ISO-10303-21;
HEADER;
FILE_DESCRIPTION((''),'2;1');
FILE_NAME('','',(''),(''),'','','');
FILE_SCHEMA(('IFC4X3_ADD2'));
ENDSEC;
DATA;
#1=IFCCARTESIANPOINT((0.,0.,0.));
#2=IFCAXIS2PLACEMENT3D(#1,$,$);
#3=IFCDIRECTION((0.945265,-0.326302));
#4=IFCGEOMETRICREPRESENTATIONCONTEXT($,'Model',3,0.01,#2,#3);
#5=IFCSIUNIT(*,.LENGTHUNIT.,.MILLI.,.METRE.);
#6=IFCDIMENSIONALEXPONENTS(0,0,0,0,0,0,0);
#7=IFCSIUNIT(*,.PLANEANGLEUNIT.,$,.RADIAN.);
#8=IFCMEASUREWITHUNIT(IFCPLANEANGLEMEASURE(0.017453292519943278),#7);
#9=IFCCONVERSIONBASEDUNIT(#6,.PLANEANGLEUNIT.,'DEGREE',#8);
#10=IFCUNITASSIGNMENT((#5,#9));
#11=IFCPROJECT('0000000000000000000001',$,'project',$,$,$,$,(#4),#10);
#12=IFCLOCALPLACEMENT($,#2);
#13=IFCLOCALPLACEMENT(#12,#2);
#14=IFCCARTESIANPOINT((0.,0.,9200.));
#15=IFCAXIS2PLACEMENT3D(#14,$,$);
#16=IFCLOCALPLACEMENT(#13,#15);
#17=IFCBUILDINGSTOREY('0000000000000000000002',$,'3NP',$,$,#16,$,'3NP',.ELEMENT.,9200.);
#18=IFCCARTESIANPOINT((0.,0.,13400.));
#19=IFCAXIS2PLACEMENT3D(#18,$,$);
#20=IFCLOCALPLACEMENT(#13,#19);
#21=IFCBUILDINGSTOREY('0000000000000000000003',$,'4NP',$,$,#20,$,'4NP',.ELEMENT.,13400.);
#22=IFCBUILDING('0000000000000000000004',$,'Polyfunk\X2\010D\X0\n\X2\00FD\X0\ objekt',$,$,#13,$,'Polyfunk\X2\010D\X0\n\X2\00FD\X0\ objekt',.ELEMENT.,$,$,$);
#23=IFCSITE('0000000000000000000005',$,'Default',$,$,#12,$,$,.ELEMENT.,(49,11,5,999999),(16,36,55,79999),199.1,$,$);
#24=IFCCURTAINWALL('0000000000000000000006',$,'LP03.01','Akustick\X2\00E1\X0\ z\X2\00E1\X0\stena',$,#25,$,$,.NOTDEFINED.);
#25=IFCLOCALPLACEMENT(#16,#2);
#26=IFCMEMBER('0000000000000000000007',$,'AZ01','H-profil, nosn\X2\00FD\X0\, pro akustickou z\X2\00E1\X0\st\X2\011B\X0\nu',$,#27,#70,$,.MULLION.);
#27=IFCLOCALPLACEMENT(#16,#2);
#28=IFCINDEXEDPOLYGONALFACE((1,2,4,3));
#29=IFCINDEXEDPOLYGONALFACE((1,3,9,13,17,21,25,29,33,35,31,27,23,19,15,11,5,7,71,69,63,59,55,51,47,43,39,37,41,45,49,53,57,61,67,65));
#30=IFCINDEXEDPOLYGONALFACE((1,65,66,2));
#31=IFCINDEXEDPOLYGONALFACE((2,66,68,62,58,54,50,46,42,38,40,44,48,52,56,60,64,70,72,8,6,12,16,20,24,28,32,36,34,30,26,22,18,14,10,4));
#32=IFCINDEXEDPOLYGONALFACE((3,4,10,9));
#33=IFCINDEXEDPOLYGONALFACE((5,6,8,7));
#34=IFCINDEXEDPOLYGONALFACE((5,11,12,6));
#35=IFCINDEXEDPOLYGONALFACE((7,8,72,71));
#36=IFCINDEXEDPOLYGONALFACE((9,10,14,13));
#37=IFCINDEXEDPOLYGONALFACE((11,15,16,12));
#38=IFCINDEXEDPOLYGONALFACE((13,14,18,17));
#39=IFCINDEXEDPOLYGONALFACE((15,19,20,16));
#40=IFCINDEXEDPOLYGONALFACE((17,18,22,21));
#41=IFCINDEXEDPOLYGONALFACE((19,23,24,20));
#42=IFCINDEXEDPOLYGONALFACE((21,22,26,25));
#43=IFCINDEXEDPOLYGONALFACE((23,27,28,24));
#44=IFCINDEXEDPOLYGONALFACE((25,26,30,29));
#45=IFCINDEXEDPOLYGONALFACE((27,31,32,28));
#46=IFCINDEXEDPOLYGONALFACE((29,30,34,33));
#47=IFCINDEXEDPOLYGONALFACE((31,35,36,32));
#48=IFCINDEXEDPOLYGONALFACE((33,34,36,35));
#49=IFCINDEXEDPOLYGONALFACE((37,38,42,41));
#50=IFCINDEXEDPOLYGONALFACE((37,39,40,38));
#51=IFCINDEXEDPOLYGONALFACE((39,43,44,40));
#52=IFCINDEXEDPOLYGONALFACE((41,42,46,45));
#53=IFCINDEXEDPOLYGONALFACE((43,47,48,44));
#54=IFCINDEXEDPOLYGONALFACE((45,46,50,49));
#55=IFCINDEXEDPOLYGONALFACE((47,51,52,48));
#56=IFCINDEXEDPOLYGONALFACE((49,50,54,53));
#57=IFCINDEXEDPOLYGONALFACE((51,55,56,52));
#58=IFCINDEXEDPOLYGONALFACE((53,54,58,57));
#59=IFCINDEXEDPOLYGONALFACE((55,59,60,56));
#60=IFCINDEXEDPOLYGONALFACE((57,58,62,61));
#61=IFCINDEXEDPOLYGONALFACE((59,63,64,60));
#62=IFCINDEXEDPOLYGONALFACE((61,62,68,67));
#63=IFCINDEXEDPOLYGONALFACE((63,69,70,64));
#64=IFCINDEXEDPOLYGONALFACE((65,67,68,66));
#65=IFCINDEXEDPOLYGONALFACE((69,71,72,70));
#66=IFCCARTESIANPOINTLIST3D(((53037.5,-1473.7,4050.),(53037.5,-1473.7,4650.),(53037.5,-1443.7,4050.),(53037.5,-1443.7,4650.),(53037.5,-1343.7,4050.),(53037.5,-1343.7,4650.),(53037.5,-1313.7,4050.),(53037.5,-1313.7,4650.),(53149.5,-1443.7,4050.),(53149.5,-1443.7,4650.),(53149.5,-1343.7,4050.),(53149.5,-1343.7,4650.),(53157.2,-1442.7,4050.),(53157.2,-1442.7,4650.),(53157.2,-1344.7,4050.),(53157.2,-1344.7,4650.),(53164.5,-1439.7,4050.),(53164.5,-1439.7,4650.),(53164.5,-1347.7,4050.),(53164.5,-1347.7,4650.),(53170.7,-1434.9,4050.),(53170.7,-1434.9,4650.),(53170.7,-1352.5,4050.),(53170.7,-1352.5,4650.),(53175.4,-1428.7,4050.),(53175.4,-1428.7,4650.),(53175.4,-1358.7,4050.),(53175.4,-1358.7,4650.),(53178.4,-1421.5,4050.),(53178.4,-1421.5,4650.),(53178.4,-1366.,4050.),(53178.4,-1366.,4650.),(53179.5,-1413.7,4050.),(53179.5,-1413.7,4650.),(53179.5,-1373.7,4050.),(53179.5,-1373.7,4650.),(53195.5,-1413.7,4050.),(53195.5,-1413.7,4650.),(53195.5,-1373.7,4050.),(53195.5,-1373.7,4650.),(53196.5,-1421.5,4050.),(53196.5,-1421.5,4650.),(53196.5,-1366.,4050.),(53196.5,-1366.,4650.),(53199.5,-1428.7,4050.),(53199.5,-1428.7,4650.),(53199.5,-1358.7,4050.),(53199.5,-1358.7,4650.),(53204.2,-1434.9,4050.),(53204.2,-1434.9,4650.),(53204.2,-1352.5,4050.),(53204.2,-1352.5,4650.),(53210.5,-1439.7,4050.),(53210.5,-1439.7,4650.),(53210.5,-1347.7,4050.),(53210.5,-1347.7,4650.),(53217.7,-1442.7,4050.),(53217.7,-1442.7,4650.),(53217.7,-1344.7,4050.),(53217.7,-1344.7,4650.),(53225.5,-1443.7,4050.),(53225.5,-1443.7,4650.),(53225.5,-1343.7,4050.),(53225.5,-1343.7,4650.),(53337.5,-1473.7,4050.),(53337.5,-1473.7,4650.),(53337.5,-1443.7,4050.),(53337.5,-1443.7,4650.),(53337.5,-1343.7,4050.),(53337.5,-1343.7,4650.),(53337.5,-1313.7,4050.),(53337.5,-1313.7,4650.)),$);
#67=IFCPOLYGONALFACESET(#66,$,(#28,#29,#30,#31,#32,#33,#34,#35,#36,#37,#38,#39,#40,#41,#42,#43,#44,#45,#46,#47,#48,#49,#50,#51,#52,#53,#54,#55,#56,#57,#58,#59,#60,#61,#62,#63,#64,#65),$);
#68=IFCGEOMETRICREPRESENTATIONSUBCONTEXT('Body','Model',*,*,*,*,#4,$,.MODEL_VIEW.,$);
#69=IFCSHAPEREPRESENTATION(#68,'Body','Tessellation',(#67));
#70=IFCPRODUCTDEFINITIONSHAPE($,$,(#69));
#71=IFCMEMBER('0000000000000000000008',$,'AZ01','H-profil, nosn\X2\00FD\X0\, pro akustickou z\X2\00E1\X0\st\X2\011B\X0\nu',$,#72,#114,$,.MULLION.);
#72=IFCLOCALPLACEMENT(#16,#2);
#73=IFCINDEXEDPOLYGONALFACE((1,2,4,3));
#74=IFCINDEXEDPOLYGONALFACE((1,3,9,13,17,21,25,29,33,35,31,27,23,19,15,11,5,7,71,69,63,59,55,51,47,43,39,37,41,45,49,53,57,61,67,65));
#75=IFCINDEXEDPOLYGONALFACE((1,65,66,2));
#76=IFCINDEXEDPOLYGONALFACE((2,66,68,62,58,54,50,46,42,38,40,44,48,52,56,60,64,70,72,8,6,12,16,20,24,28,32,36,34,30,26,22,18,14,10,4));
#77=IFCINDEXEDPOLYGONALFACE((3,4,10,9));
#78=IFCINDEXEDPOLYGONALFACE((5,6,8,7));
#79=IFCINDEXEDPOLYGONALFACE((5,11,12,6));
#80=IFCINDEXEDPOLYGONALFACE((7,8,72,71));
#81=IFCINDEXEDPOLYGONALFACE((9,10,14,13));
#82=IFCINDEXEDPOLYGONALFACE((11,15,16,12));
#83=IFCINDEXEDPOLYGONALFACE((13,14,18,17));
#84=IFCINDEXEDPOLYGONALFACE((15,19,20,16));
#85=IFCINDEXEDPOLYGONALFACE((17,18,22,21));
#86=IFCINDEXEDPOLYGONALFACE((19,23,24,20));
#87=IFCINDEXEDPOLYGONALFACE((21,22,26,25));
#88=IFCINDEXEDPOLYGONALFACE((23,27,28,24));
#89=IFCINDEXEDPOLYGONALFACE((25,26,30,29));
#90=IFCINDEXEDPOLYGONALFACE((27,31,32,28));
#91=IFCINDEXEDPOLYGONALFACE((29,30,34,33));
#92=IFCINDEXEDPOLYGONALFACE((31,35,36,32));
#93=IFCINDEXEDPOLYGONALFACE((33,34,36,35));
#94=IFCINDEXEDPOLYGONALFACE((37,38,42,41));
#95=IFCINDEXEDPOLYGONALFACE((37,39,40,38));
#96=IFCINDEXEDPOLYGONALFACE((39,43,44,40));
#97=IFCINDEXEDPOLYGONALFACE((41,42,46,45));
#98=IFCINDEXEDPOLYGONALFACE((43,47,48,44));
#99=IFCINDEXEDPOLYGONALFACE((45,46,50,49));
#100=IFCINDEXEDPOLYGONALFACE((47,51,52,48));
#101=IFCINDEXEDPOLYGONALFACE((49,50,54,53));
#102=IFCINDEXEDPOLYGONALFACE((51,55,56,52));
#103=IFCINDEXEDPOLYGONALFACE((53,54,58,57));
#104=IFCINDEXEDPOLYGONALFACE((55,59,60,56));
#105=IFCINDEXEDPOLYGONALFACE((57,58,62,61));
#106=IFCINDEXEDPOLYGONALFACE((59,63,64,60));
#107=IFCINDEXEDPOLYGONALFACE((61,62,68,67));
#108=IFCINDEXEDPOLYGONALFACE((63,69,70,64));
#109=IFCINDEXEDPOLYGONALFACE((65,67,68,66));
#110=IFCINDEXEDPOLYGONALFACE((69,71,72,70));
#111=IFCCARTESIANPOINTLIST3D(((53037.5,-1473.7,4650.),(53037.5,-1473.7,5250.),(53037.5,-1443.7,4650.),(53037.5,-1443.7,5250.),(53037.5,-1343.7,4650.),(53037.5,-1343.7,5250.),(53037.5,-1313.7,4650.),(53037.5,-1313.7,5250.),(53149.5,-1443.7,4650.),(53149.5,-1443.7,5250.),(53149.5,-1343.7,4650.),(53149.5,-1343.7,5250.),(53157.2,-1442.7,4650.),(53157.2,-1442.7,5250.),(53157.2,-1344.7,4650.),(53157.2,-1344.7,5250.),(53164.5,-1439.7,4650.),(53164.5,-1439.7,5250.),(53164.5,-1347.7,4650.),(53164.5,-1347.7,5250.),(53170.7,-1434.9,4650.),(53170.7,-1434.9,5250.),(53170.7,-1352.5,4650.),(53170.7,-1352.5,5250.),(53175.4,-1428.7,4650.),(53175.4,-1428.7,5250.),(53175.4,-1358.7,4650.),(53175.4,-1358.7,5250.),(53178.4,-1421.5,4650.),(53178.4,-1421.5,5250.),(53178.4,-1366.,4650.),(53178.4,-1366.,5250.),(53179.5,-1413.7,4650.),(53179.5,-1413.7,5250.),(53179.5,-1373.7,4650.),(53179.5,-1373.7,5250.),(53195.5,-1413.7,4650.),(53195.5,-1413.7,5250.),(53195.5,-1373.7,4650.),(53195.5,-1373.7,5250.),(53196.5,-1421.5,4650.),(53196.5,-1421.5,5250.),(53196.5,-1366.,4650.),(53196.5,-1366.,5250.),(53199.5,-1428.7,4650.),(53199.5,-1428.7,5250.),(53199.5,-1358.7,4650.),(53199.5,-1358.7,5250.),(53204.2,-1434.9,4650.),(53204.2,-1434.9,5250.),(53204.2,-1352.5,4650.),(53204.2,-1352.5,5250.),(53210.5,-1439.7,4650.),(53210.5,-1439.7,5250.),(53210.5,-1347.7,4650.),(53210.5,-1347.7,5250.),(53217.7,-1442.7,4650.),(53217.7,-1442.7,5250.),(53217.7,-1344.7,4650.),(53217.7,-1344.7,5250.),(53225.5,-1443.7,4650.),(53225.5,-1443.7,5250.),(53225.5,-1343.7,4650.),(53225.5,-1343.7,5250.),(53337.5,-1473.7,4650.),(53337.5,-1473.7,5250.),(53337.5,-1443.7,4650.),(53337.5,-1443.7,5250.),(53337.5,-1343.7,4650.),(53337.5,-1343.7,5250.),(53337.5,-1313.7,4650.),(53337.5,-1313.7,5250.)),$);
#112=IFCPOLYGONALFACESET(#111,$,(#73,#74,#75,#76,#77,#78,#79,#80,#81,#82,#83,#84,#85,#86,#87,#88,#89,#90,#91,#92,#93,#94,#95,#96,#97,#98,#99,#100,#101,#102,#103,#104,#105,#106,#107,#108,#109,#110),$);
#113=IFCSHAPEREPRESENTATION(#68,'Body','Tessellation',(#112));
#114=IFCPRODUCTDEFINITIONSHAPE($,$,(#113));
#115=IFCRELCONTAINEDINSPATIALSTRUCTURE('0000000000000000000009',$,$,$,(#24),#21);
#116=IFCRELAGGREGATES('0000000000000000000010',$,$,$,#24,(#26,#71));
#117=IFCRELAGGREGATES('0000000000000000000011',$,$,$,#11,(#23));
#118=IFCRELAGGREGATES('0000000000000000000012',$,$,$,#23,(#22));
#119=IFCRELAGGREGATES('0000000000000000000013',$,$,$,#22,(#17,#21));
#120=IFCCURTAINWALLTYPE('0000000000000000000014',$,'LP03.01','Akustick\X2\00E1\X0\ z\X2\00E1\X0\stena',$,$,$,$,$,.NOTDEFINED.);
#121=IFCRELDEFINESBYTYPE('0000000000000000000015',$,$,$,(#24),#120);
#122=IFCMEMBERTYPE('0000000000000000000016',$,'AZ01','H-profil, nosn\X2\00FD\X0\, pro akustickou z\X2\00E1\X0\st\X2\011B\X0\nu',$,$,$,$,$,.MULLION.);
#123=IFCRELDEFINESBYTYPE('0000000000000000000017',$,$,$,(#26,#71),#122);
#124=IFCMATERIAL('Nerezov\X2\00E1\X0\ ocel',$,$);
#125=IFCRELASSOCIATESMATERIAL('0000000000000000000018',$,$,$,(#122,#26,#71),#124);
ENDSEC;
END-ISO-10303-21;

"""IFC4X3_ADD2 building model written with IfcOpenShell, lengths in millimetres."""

from ifc_helpers import new_model, entity, si_unit, converted_unit, direction, frame, frame_2d, origin, place, context, subcontext, project, spatial, polyline, circle_curve, parameter, trimmed, segment, composite_curve, outline, extrude, source, transform, mapped, material, material_profile, profile_set, profile_usage, type_object, element, aggregate, save


model = new_model("IFC4X3_ADD2")

# Units and contexts
model_context = context("Model", 3, precision=0.01, world=origin(), true_north=direction((0.945265, -0.326302)))
body_context = subcontext(model_context, "Body", "Model", "MODEL_VIEW")
ifc_project = project(units=[si_unit("LENGTHUNIT", "METRE", prefix="MILLI"), converted_unit("PLANEANGLEUNIT", "DEGREE", entity("IfcPlaneAngleMeasure", 0.017453292519943278), si_unit("PLANEANGLEUNIT", "RADIAN"), dimensions=[0, 0, 0, 0, 0, 0, 0])], contexts=[model_context])

# Site, building, storey
site_placement = place(None, origin())
site = spatial("IfcSite", under=ifc_project, at=site_placement, Name="Default", CompositionType="ELEMENT", RefLatitude=(49, 11, 5, 999999), RefLongitude=(16, 36, 55, 79999), RefElevation=199.1)
building_placement = place(site_placement, origin())
building = spatial("IfcBuilding", under=site, at=building_placement, Name="Polyfunkčný objekt", LongName="Polyfunkčný objekt", CompositionType="ELEMENT")
storey_1_placement = place(building_placement, frame((0.0, 0.0, 9200.0)))
storey_1 = spatial("IfcBuildingStorey", under=building, at=storey_1_placement, Name="3NP", LongName="3NP", CompositionType="ELEMENT", Elevation=9200.0)

# Shared definitions
storey_2_placement = place(building_placement, frame((0.0, 0.0, 13400.0)))
storey_2 = spatial("IfcBuildingStorey", under=building, at=storey_2_placement, Name="4NP", LongName="4NP", CompositionType="ELEMENT", Elevation=13400.0)

# Curtain wall, members
curtain_wall_type_1 = type_object("IfcCurtainWallType", Name="LP03.01", Description="Akustická zástena", PredefinedType="NOTDEFINED")
curtain_wall_1_placement = place(storey_2_placement, frame((0.0, 0.0, -13400.0)))
curtain_wall_1 = element("IfcCurtainWall", 1, at=curtain_wall_1_placement, inside=storey_2, type_object=curtain_wall_type_1, Name="LP03.01", Description="Akustická zástena", PredefinedType="NOTDEFINED")
ifc_material_1 = material(Name="Nerezová ocel")
ifc_material_profile_1 = material_profile(ifc_material_1, outline(composite_curve([segment(polyline([(50.0, -150.0), (80.0, -150.0)]), True, "CONTINUOUS"), segment(polyline([(80.0, -150.0), (80.0, 150.0)]), True, "CONTINUOUS"), segment(polyline([(80.0, 150.0), (50.0, 150.0)]), True, "CONTINUOUS"), segment(polyline([(50.0, 150.0), (50.0, 38.0)]), True, "CONTINUOUS"), segment(trimmed(circle_curve(frame_2d((20.0, 38.0), x_axis=(0.0, 1.0)), 30.0), [parameter(180.0)], [parameter(270.0)], True, "PARAMETER"), False, "CONTINUOUS"), segment(polyline([(20.0, 8.0), (-20.0, 8.0)]), True, "CONTINUOUS"), segment(trimmed(circle_curve(frame_2d((-20.0, 38.0), x_axis=(0.0, 1.0)), 30.0), [parameter(90.0)], [parameter(180.0)], True, "PARAMETER"), False, "CONTINUOUS"), segment(polyline([(-50.0, 38.0), (-50.0, 150.0)]), True, "CONTINUOUS"), segment(polyline([(-50.0, 150.0), (-80.0, 150.0)]), True, "CONTINUOUS"), segment(polyline([(-80.0, 150.0), (-80.0, -150.0)]), True, "CONTINUOUS"), segment(polyline([(-80.0, -150.0), (-50.0, -150.0)]), True, "CONTINUOUS"), segment(polyline([(-50.0, -150.0), (-50.0, -38.0)]), True, "CONTINUOUS"), segment(trimmed(circle_curve(frame_2d((-20.0, -38.0), x_axis=(0.0, 1.0)), 30.0), [parameter(0.0)], [parameter(90.0)], True, "PARAMETER"), False, "CONTINUOUS"), segment(polyline([(-20.0, -8.0), (20.0, -8.0)]), True, "CONTINUOUS"), segment(trimmed(circle_curve(frame_2d((20.0, -38.0), x_axis=(0.0, 1.0)), 30.0), [parameter(270.0)], [parameter(0.0)], True, "PARAMETER"), False, "CONTINUOUS"), segment(polyline([(50.0, -38.0), (50.0, -150.0)]), True, "CONTINUOUS")], self_intersect=False)), Name="Profil zástena")
ifc_profile_set_1 = profile_set([ifc_material_profile_1], Name="Profil zástena")
ifc_profile_usage_1 = profile_usage(ifc_profile_set_1)
member_type_1 = type_object("IfcMemberType", Name="AZ01", Description="H-profil, nosný, pro akustickou zástěnu", PredefinedType="MULLION", material=ifc_profile_set_1)
shared_shape_1 = source(origin(), body_context, "Body", "SweptSolid", [
    extrude(outline(composite_curve([segment(polyline([(50.0, -150.0), (80.0, -150.0)]), True, "CONTINUOUS"), segment(polyline([(80.0, -150.0), (80.0, 150.0)]), True, "CONTINUOUS"), segment(polyline([(80.0, 150.0), (50.0, 150.0)]), True, "CONTINUOUS"), segment(polyline([(50.0, 150.0), (50.0, 38.0)]), True, "CONTINUOUS"), segment(trimmed(circle_curve(frame_2d((20.0, 38.0), x_axis=(0.0, 1.0)), 30.0), [parameter(180.0)], [parameter(270.0)], True, "PARAMETER"), False, "CONTINUOUS"), segment(polyline([(20.0, 8.0), (-20.0, 8.0)]), True, "CONTINUOUS"), segment(trimmed(circle_curve(frame_2d((-20.0, 38.0), x_axis=(0.0, 1.0)), 30.0), [parameter(90.0)], [parameter(180.0)], True, "PARAMETER"), False, "CONTINUOUS"), segment(polyline([(-50.0, 38.0), (-50.0, 150.0)]), True, "CONTINUOUS"), segment(polyline([(-50.0, 150.0), (-80.0, 150.0)]), True, "CONTINUOUS"), segment(polyline([(-80.0, 150.0), (-80.0, -150.0)]), True, "CONTINUOUS"), segment(polyline([(-80.0, -150.0), (-50.0, -150.0)]), True, "CONTINUOUS"), segment(polyline([(-50.0, -150.0), (-50.0, -38.0)]), True, "CONTINUOUS"), segment(trimmed(circle_curve(frame_2d((-20.0, -38.0), x_axis=(0.0, 1.0)), 30.0), [parameter(0.0)], [parameter(90.0)], True, "PARAMETER"), False, "CONTINUOUS"), segment(polyline([(-20.0, -8.0), (20.0, -8.0)]), True, "CONTINUOUS"), segment(trimmed(circle_curve(frame_2d((20.0, -38.0), x_axis=(0.0, 1.0)), 30.0), [parameter(270.0)], [parameter(0.0)], True, "PARAMETER"), False, "CONTINUOUS"), segment(polyline([(50.0, -38.0), (50.0, -150.0)]), True, "CONTINUOUS")], self_intersect=False)), frame((0.0, 0.0, -600.0), z_axis=(0.0, 0.0, 1.0), x_axis=(0.0, -1.0, 0.0)), (0.0, 0.0, 1.0), 600.0),
])
member_1_placement = place(curtain_wall_1_placement, frame((53187.5, -1393.7, 13250.0), z_axis=(0.0, 0.0, -1.0), x_axis=(1.0, 0.0, 0.0)))
member_1 = element("IfcMember", 2, at=member_1_placement, type_object=member_type_1, material=ifc_profile_usage_1, Name="AZ01", Description="H-profil, nosný, pro akustickou zástěnu", PredefinedType="MULLION", context=body_context, shape_type="MappedRepresentation", body=[
    mapped(shared_shape_1, transform((0.0, 0.0, 0.0), scale=1.0)),
])
shared_shape_2 = source(origin(), body_context, "Body", "SweptSolid", [
    extrude(outline(composite_curve([segment(polyline([(50.0, -150.0), (80.0, -150.0)]), True, "CONTINUOUS"), segment(polyline([(80.0, -150.0), (80.0, 150.0)]), True, "CONTINUOUS"), segment(polyline([(80.0, 150.0), (50.0, 150.0)]), True, "CONTINUOUS"), segment(polyline([(50.0, 150.0), (50.0, 38.0)]), True, "CONTINUOUS"), segment(trimmed(circle_curve(frame_2d((20.0, 38.0), x_axis=(0.0, 1.0)), 30.0), [parameter(180.0)], [parameter(270.0)], True, "PARAMETER"), False, "CONTINUOUS"), segment(polyline([(20.0, 8.0), (-20.0, 8.0)]), True, "CONTINUOUS"), segment(trimmed(circle_curve(frame_2d((-20.0, 38.0), x_axis=(0.0, 1.0)), 30.0), [parameter(90.0)], [parameter(180.0)], True, "PARAMETER"), False, "CONTINUOUS"), segment(polyline([(-50.0, 38.0), (-50.0, 150.0)]), True, "CONTINUOUS"), segment(polyline([(-50.0, 150.0), (-80.0, 150.0)]), True, "CONTINUOUS"), segment(polyline([(-80.0, 150.0), (-80.0, -150.0)]), True, "CONTINUOUS"), segment(polyline([(-80.0, -150.0), (-50.0, -150.0)]), True, "CONTINUOUS"), segment(polyline([(-50.0, -150.0), (-50.0, -38.0)]), True, "CONTINUOUS"), segment(trimmed(circle_curve(frame_2d((-20.0, -38.0), x_axis=(0.0, 1.0)), 30.0), [parameter(0.0)], [parameter(90.0)], True, "PARAMETER"), False, "CONTINUOUS"), segment(polyline([(-20.0, -8.0), (20.0, -8.0)]), True, "CONTINUOUS"), segment(trimmed(circle_curve(frame_2d((20.0, -38.0), x_axis=(0.0, 1.0)), 30.0), [parameter(270.0)], [parameter(0.0)], True, "PARAMETER"), False, "CONTINUOUS"), segment(polyline([(50.0, -38.0), (50.0, -150.0)]), True, "CONTINUOUS")], self_intersect=False)), frame((0.0, 0.0, -600.0), z_axis=(0.0, 0.0, 1.0), x_axis=(0.0, -1.0, 0.0)), (0.0, 0.0, 1.0), 600.0),
])
member_2_placement = place(curtain_wall_1_placement, frame((53187.5, -1393.7, 13850.0), z_axis=(0.0, 0.0, -1.0), x_axis=(1.0, 0.0, 0.0)))
member_2 = element("IfcMember", 3, at=member_2_placement, type_object=member_type_1, material=ifc_profile_usage_1, Name="AZ01", Description="H-profil, nosný, pro akustickou zástěnu", PredefinedType="MULLION", context=body_context, shape_type="MappedRepresentation", body=[
    mapped(shared_shape_2, transform((0.0, 0.0, 0.0), scale=1.0)),
])

aggregate(curtain_wall_1, [member_1, member_2])

save(model, "model.ifc")
